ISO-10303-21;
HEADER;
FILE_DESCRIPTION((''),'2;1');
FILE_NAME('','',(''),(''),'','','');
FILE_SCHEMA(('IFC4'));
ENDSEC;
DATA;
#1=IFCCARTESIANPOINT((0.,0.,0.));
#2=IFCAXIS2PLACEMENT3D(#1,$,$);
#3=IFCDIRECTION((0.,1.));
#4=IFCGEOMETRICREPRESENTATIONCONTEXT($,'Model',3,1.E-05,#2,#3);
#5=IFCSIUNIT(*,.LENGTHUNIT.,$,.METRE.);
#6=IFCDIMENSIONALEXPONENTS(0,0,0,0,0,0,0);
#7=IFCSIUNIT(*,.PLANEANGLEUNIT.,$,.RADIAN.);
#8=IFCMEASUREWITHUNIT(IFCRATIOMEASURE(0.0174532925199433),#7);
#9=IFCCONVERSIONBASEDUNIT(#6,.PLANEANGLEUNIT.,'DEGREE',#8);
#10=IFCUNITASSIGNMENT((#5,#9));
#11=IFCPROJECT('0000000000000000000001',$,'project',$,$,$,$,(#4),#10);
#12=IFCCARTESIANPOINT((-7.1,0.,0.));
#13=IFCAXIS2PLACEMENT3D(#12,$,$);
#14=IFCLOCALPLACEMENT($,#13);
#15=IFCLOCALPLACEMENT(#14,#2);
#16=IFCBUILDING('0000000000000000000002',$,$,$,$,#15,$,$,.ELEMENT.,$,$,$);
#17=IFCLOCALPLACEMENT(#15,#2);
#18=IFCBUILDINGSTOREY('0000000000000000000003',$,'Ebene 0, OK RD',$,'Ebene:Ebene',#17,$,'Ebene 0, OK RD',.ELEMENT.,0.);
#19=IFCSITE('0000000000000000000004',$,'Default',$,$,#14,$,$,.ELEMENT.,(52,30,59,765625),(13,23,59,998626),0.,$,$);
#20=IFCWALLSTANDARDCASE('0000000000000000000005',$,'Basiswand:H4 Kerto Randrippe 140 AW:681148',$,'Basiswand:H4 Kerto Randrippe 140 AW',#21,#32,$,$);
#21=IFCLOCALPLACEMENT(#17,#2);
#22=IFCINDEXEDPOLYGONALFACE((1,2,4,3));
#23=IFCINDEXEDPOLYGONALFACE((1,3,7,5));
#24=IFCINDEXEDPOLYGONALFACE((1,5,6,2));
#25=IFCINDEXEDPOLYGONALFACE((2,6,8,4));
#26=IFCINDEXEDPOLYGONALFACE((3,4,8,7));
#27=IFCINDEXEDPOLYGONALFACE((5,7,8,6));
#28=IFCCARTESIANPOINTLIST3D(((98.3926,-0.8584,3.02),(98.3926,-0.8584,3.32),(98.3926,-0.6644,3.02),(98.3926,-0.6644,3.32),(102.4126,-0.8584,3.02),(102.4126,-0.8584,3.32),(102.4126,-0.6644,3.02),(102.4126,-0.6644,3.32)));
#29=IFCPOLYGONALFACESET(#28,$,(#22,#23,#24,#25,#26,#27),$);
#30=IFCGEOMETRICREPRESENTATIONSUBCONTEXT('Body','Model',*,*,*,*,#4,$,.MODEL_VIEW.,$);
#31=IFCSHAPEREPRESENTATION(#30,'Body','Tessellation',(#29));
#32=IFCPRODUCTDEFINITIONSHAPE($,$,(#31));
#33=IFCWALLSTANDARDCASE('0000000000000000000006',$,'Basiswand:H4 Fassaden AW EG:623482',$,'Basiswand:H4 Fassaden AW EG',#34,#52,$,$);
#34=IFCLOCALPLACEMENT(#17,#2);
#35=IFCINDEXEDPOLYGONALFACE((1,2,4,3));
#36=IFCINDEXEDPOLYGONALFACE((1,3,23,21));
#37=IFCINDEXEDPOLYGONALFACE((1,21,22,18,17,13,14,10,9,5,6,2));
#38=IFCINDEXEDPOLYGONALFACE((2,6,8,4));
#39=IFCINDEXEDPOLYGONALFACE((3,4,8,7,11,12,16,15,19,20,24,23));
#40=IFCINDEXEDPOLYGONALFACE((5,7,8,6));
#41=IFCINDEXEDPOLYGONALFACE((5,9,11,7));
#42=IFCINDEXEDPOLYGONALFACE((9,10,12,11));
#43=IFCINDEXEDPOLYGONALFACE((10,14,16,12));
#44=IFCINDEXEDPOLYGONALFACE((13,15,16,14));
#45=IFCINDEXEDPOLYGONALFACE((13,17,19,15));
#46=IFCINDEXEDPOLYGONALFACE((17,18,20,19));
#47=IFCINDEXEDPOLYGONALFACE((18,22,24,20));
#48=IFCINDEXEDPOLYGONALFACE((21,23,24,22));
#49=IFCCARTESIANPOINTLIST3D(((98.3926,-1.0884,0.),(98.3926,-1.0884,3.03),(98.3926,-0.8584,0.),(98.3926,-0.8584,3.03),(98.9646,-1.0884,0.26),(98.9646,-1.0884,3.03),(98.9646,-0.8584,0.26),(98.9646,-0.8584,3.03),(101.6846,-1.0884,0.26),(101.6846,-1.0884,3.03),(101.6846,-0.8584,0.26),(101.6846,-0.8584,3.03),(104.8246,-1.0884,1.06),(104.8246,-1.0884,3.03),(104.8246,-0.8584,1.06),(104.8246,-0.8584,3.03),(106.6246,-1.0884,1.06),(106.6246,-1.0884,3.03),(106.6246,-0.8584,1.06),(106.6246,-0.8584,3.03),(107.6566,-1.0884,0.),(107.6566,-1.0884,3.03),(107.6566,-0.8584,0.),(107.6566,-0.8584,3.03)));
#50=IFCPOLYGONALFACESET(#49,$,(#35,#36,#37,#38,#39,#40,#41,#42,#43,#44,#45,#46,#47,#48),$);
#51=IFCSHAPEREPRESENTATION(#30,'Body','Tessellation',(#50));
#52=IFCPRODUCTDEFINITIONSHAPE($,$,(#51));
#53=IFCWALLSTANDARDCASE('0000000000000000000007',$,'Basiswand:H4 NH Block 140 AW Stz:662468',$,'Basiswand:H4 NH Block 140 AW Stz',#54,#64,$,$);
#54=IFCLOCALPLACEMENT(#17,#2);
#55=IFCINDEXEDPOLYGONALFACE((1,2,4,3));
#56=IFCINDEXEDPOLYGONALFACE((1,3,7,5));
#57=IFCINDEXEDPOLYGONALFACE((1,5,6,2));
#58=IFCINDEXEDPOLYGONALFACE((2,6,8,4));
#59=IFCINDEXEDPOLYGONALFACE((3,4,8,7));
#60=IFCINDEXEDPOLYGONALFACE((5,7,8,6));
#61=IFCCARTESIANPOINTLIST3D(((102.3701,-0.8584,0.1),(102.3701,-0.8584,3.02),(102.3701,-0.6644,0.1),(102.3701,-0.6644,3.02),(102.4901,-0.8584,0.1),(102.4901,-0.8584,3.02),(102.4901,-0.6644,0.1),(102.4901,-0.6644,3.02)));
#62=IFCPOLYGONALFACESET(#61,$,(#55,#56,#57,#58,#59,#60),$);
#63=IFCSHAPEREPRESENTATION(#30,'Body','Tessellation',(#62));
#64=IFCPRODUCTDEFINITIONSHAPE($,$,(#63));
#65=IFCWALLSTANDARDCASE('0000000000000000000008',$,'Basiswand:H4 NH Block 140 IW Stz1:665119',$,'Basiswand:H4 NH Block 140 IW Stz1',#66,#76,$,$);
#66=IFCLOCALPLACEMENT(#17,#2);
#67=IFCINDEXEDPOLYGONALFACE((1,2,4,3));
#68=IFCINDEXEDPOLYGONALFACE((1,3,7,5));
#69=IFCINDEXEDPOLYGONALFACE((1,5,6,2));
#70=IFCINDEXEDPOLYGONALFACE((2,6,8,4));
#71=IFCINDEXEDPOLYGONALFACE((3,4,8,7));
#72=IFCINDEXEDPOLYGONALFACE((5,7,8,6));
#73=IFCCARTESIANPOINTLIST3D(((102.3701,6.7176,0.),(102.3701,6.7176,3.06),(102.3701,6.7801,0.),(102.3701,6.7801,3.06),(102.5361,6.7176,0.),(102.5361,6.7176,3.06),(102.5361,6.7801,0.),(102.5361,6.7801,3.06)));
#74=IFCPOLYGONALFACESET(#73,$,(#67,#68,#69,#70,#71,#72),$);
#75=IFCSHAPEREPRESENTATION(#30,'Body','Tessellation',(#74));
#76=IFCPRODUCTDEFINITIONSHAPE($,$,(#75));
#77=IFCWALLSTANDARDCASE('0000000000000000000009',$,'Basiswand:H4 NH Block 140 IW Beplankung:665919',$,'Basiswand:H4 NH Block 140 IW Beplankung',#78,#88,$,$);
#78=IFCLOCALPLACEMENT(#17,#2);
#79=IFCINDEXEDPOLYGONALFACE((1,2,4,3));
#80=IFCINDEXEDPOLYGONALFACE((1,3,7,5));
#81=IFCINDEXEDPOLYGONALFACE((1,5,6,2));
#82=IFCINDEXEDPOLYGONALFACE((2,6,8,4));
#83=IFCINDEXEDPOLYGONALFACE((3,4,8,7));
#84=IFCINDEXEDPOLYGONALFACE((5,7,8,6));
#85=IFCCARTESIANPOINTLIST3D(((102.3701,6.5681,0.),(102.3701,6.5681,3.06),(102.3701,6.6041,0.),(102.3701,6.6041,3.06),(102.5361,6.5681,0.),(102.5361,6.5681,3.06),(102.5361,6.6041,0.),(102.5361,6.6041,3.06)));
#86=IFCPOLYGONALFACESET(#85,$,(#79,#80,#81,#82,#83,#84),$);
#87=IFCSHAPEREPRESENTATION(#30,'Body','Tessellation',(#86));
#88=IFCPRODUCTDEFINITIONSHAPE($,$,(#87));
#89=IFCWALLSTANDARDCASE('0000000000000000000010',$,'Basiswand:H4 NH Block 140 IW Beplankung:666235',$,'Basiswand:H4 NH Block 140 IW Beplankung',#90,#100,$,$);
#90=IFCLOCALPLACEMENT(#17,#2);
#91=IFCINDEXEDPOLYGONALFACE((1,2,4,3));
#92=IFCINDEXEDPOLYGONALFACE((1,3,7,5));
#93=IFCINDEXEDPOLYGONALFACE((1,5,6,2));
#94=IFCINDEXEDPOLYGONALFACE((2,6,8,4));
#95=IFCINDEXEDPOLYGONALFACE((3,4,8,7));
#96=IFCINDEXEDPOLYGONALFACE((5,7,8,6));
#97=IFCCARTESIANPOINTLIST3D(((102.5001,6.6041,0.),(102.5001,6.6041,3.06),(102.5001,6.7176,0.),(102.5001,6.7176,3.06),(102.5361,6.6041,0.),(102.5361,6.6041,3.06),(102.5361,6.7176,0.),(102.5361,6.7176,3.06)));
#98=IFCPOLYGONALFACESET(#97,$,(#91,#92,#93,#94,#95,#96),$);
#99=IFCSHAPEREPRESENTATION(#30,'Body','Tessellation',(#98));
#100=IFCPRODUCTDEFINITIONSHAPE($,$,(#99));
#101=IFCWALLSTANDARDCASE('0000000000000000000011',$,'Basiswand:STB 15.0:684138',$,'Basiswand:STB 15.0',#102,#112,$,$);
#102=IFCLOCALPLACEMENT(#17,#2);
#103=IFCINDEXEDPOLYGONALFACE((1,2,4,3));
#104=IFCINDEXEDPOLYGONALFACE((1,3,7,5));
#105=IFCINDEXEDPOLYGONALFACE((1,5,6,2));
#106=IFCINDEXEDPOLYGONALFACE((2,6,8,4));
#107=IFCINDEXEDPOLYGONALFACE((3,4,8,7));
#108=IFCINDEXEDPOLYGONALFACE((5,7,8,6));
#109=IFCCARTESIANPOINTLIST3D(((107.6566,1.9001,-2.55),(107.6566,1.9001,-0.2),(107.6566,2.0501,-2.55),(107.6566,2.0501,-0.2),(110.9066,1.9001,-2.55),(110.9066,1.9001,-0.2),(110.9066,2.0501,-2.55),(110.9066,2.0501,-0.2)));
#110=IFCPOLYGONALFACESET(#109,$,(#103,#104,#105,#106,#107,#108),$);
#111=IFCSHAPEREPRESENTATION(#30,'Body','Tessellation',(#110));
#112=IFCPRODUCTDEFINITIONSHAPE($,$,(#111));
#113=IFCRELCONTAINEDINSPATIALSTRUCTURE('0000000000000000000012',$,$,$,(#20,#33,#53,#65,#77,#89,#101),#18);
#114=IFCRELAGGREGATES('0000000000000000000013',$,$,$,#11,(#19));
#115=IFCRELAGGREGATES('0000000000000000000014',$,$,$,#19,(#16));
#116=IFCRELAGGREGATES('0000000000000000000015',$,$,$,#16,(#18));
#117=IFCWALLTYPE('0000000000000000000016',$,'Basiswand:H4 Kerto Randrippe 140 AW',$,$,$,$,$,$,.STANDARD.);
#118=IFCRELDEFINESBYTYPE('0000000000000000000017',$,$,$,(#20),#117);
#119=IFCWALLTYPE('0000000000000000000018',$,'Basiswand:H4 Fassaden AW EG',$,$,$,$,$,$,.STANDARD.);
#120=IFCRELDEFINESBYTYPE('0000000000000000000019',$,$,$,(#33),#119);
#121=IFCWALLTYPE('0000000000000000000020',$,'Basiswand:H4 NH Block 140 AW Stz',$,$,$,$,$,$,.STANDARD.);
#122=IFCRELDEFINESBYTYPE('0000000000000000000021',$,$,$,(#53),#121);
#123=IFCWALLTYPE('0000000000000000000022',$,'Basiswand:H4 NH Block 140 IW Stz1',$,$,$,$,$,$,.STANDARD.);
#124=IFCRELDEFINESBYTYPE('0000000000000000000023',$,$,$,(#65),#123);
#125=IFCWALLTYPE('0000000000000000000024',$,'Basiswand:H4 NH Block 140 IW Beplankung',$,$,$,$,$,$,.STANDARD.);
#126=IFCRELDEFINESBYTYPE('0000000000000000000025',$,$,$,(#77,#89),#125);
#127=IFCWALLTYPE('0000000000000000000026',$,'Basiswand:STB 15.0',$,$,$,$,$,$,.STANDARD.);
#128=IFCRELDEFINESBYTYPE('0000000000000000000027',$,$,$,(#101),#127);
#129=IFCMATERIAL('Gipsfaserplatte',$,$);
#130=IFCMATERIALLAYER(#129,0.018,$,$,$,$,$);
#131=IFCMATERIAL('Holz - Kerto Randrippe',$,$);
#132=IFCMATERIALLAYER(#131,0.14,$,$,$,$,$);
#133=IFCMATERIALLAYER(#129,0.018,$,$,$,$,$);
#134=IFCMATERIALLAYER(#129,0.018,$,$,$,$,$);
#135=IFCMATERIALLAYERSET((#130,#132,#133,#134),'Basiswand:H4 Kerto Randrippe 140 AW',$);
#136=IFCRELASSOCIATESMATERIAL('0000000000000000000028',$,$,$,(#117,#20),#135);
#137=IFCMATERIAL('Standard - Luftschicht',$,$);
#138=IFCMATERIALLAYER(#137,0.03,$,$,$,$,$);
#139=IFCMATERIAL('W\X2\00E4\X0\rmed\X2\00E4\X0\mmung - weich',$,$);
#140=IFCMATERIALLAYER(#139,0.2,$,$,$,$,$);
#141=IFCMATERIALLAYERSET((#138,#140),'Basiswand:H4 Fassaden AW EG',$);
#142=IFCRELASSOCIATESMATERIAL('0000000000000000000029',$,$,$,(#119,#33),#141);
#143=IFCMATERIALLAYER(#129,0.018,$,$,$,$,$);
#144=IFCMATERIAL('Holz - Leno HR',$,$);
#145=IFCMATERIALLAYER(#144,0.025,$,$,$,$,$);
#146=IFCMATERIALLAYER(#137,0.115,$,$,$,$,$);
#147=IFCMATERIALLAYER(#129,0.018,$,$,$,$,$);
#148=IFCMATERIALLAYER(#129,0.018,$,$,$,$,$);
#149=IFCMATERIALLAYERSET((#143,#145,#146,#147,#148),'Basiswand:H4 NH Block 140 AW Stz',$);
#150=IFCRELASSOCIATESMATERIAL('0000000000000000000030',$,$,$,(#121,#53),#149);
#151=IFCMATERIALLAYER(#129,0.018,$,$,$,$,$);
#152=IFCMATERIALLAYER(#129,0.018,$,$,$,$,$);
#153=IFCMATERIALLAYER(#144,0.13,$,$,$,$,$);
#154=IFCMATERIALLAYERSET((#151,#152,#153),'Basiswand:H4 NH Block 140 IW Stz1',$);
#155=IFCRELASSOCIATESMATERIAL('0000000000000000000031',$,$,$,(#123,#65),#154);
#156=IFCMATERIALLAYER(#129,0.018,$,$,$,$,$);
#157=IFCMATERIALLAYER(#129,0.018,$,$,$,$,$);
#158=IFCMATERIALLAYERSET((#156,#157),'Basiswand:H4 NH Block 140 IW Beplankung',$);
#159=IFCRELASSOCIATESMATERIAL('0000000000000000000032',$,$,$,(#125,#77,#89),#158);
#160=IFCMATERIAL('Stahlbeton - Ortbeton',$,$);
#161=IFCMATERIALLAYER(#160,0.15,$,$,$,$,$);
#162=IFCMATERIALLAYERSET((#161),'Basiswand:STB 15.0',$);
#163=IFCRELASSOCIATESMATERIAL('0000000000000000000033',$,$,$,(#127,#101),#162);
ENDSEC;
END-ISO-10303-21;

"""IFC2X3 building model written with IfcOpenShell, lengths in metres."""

from ifc_helpers import new_model, entity, si_unit, converted_unit, direction, frame, frame_2d, origin, place, context, subcontext, project, spatial, rectangle, extrude, material, layer, layer_set, layer_usage, type_object, element, save


model = new_model("IFC2X3")

# Units and contexts
model_context = context("Model", 3, precision=1e-05, world=origin(), true_north=direction((0.0, 1.0)))
body_context = subcontext(model_context, "Body", "Model", "MODEL_VIEW")
ifc_project = project(units=[si_unit("LENGTHUNIT", "METRE"), converted_unit("PLANEANGLEUNIT", "DEGREE", entity("IfcRatioMeasure", 0.0174532925199433), si_unit("PLANEANGLEUNIT", "RADIAN"), dimensions=[0, 0, 0, 0, 0, 0, 0])], contexts=[model_context])

# Site, building, storey
site_placement = place(None, frame((-7.1, 0.0, 0.0)))
site = spatial("IfcSite", under=ifc_project, at=site_placement, Name="Default", CompositionType="ELEMENT", RefLatitude=(52, 30, 59, 765625), RefLongitude=(13, 23, 59, 998626), RefElevation=0.0)
building_placement = place(site_placement, origin())
building = spatial("IfcBuilding", under=site, at=building_placement, CompositionType="ELEMENT")
storey_placement = place(building_placement, origin())
storey = spatial("IfcBuildingStorey", under=building, at=storey_placement, Name="Ebene 0, OK RD", ObjectType="Ebene:Ebene", LongName="Ebene 0, OK RD", CompositionType="ELEMENT", Elevation=0.0)

# Shared definitions
ifc_material_1 = material(Name="Gipsfaserplatte")
ifc_material_2 = material(Name="Holz - Leno HR")

# Shared definitions
ifc_material_3 = material(Name="Stahlbeton - Ortbeton")

# Wall
ifc_layer_1 = layer(ifc_material_1, 0.018)
ifc_material_4 = material(Name="Holz - Kerto Randrippe")
ifc_layer_2 = layer(ifc_material_4, 0.14)
ifc_layer_3 = layer(ifc_material_1, 0.018)
ifc_layer_4 = layer(ifc_material_1, 0.018)
ifc_layer_set_1 = layer_set([ifc_layer_1, ifc_layer_2, ifc_layer_3, ifc_layer_4], Name="Basiswand:H4 Kerto Randrippe 140 AW")
wall_type_1 = type_object("IfcWallType", Name="Basiswand:H4 Kerto Randrippe 140 AW", PredefinedType="STANDARD", material=ifc_layer_set_1)
ifc_layer_usage_1 = layer_usage(ifc_layer_set_1, "AXIS2", "NEGATIVE", 0.097)
wall_1_placement = place(storey_placement, frame((102.4126, -0.7614, 3.02), z_axis=(0.0, 0.0, 1.0), x_axis=(-1.0, 0.0, 0.0)))
element("IfcWallStandardCase", 1, at=wall_1_placement, inside=storey, type_object=wall_type_1, material=ifc_layer_usage_1, Name="Basiswand:H4 Kerto Randrippe 140 AW:681148", ObjectType="Basiswand:H4 Kerto Randrippe 140 AW", context=body_context, shape_type="SweptSolid", body=[
    extrude(rectangle(XDim=4.02, YDim=0.194, at=frame_2d((2.01, 0.0), x_axis=(-1.0, 0.0))), origin(), (0.0, 0.0, 1.0), 0.3),
])

# Wall, openings
ifc_material_5 = material(Name="Standard - Luftschicht")
ifc_layer_5 = layer(ifc_material_5, 0.03)
ifc_material_6 = material(Name="Wärmedämmung - weich")
ifc_layer_6 = layer(ifc_material_6, 0.2)
ifc_layer_set_2 = layer_set([ifc_layer_5, ifc_layer_6], Name="Basiswand:H4 Fassaden AW EG")
ifc_layer_usage_2 = layer_usage(ifc_layer_set_2, "AXIS2", "NEGATIVE", 0.115)
wall_type_2 = type_object("IfcWallType", Name="Basiswand:H4 Fassaden AW EG", PredefinedType="STANDARD", material=ifc_layer_set_2)
wall_2_placement = place(storey_placement, frame((107.6566, -0.9734, 0.0), z_axis=(0.0, 0.0, 1.0), x_axis=(-1.0, 0.0, 0.0)))
wall_2 = element("IfcWallStandardCase", 2, at=wall_2_placement, inside=storey, type_object=wall_type_2, material=ifc_layer_usage_2, Name="Basiswand:H4 Fassaden AW EG:623482", ObjectType="Basiswand:H4 Fassaden AW EG", context=body_context, shape_type="SweptSolid", body=[
    extrude(rectangle(XDim=9.264, YDim=0.23, at=frame_2d((4.632, 0.0), x_axis=(-1.0, 0.0))), origin(), (0.0, 0.0, 1.0), 3.03),
])
opening_1_placement = place(wall_2_placement, origin())
element("IfcOpeningElement", 3, at=opening_1_placement, cuts=wall_2, ObjectType="Opening", context=body_context, shape_type="SweptSolid", body=[
    extrude(rectangle(XDim=2.8, YDim=2.72, at=frame_2d((0.0, 0.0), x_axis=(0.0, 1.0))), frame((7.332, -0.2674, 1.66), z_axis=(0.0, 1.0, 0.0), x_axis=(-1.0, 0.0, 0.0)), (0.0, 0.0, 1.0), 0.5348),
])
opening_2_placement = place(wall_2_placement, frame((2.832, 0.115, 1.06)))
element("IfcOpeningElement", 4, at=opening_2_placement, cuts=wall_2, ObjectType="Opening", context=body_context, shape_type="SweptSolid", body=[
    extrude(rectangle(XDim=1.97, YDim=1.8, at=frame_2d((0.985, 0.9), x_axis=(1.0, 0.0))), frame((0.0, 0.0, 0.0), z_axis=(0.0, -1.0, 0.0), x_axis=(0.0, 0.0, 1.0)), (0.0, 0.0, 1.0), 0.23),
])

# Walls
ifc_layer_7 = layer(ifc_material_1, 0.018)
ifc_layer_8 = layer(ifc_material_2, 0.025)
ifc_layer_9 = layer(ifc_material_5, 0.115)
ifc_layer_10 = layer(ifc_material_1, 0.018)
ifc_layer_11 = layer(ifc_material_1, 0.018)
ifc_layer_set_3 = layer_set([ifc_layer_7, ifc_layer_8, ifc_layer_9, ifc_layer_10, ifc_layer_11], Name="Basiswand:H4 NH Block 140 AW Stz")
ifc_layer_usage_3 = layer_usage(ifc_layer_set_3, "AXIS2", "NEGATIVE", 0.097)
wall_type_3 = type_object("IfcWallType", Name="Basiswand:H4 NH Block 140 AW Stz", PredefinedType="STANDARD", material=ifc_layer_set_3)
wall_3_placement = place(storey_placement, frame((102.4901, -0.7614, 0.1), z_axis=(0.0, 0.0, 1.0), x_axis=(-1.0, 0.0, 0.0)))
element("IfcWallStandardCase", 5, at=wall_3_placement, inside=storey, type_object=wall_type_3, material=ifc_layer_usage_3, Name="Basiswand:H4 NH Block 140 AW Stz:662468", ObjectType="Basiswand:H4 NH Block 140 AW Stz", context=body_context, shape_type="SweptSolid", body=[
    extrude(rectangle(XDim=0.12, YDim=0.194, at=frame_2d((0.06, 0.0), x_axis=(-1.0, 0.0))), origin(), (0.0, 0.0, 1.0), 2.92),
])
ifc_layer_12 = layer(ifc_material_1, 0.018)
ifc_layer_13 = layer(ifc_material_1, 0.018)
ifc_layer_14 = layer(ifc_material_2, 0.13)
ifc_layer_set_4 = layer_set([ifc_layer_12, ifc_layer_13, ifc_layer_14], Name="Basiswand:H4 NH Block 140 IW Stz1")
ifc_layer_usage_4 = layer_usage(ifc_layer_set_4, "AXIS2", "NEGATIVE", 0.083)
wall_type_4 = type_object("IfcWallType", Name="Basiswand:H4 NH Block 140 IW Stz1", PredefinedType="STANDARD", material=ifc_layer_set_4)
wall_4_placement = place(storey_placement, frame((102.4531, 6.7801, 0.0), z_axis=(0.0, 0.0, 1.0), x_axis=(0.0, -1.0, 0.0)))
element("IfcWallStandardCase", 6, at=wall_4_placement, inside=storey, type_object=wall_type_4, material=ifc_layer_usage_4, Name="Basiswand:H4 NH Block 140 IW Stz1:665119", ObjectType="Basiswand:H4 NH Block 140 IW Stz1", context=body_context, shape_type="SweptSolid", body=[
    extrude(rectangle(XDim=0.0625, YDim=0.166, at=frame_2d((0.0313, 0.0), x_axis=(-1.0, 0.0))), origin(), (0.0, 0.0, 1.0), 3.06),
])
ifc_layer_15 = layer(ifc_material_1, 0.018)
ifc_layer_16 = layer(ifc_material_1, 0.018)
ifc_layer_set_5 = layer_set([ifc_layer_15, ifc_layer_16], Name="Basiswand:H4 NH Block 140 IW Beplankung")
ifc_layer_usage_5 = layer_usage(ifc_layer_set_5, "AXIS2", "NEGATIVE", 0.018)
wall_type_5 = type_object("IfcWallType", Name="Basiswand:H4 NH Block 140 IW Beplankung", PredefinedType="STANDARD", material=ifc_layer_set_5)
wall_5_placement = place(storey_placement, frame((102.5361, 6.5861, 0.0), z_axis=(0.0, 0.0, 1.0), x_axis=(-1.0, 0.0, 0.0)))
element("IfcWallStandardCase", 7, at=wall_5_placement, inside=storey, type_object=wall_type_5, material=ifc_layer_usage_5, Name="Basiswand:H4 NH Block 140 IW Beplankung:665919", ObjectType="Basiswand:H4 NH Block 140 IW Beplankung", context=body_context, shape_type="SweptSolid", body=[
    extrude(rectangle(XDim=0.166, YDim=0.036, at=frame_2d((0.083, 0.0), x_axis=(-1.0, 0.0))), origin(), (0.0, 0.0, 1.0), 3.06),
])
ifc_layer_usage_6 = layer_usage(ifc_layer_set_5, "AXIS2", "NEGATIVE", 0.018)
wall_6_placement = place(storey_placement, frame((102.5181, 6.7176, 0.0), z_axis=(0.0, 0.0, 1.0), x_axis=(0.0, -1.0, 0.0)))
element("IfcWallStandardCase", 8, at=wall_6_placement, inside=storey, type_object=wall_type_5, material=ifc_layer_usage_6, Name="Basiswand:H4 NH Block 140 IW Beplankung:666235", ObjectType="Basiswand:H4 NH Block 140 IW Beplankung", context=body_context, shape_type="SweptSolid", body=[
    extrude(rectangle(XDim=0.1135, YDim=0.036, at=frame_2d((0.0567, 0.0), x_axis=(-1.0, 0.0))), origin(), (0.0, 0.0, 1.0), 3.06),
])
ifc_layer_17 = layer(ifc_material_3, 0.15)
ifc_layer_set_6 = layer_set([ifc_layer_17], Name="Basiswand:STB 15.0")
ifc_layer_usage_7 = layer_usage(ifc_layer_set_6, "AXIS2", "POSITIVE", -0.075)
wall_type_6 = type_object("IfcWallType", Name="Basiswand:STB 15.0", PredefinedType="STANDARD", material=ifc_layer_set_6)
wall_7_placement = place(storey_placement, frame((107.6566, 1.9751, -2.55)))
element("IfcWallStandardCase", 9, at=wall_7_placement, inside=storey, type_object=wall_type_6, material=ifc_layer_usage_7, Name="Basiswand:STB 15.0:684138", ObjectType="Basiswand:STB 15.0", context=body_context, shape_type="SweptSolid", body=[
    extrude(rectangle(XDim=3.25, YDim=0.15, at=frame_2d((1.625, 0.0), x_axis=(-1.0, 0.0))), origin(), (0.0, 0.0, 1.0), 2.35),
])

save(model, "model.ifc")
